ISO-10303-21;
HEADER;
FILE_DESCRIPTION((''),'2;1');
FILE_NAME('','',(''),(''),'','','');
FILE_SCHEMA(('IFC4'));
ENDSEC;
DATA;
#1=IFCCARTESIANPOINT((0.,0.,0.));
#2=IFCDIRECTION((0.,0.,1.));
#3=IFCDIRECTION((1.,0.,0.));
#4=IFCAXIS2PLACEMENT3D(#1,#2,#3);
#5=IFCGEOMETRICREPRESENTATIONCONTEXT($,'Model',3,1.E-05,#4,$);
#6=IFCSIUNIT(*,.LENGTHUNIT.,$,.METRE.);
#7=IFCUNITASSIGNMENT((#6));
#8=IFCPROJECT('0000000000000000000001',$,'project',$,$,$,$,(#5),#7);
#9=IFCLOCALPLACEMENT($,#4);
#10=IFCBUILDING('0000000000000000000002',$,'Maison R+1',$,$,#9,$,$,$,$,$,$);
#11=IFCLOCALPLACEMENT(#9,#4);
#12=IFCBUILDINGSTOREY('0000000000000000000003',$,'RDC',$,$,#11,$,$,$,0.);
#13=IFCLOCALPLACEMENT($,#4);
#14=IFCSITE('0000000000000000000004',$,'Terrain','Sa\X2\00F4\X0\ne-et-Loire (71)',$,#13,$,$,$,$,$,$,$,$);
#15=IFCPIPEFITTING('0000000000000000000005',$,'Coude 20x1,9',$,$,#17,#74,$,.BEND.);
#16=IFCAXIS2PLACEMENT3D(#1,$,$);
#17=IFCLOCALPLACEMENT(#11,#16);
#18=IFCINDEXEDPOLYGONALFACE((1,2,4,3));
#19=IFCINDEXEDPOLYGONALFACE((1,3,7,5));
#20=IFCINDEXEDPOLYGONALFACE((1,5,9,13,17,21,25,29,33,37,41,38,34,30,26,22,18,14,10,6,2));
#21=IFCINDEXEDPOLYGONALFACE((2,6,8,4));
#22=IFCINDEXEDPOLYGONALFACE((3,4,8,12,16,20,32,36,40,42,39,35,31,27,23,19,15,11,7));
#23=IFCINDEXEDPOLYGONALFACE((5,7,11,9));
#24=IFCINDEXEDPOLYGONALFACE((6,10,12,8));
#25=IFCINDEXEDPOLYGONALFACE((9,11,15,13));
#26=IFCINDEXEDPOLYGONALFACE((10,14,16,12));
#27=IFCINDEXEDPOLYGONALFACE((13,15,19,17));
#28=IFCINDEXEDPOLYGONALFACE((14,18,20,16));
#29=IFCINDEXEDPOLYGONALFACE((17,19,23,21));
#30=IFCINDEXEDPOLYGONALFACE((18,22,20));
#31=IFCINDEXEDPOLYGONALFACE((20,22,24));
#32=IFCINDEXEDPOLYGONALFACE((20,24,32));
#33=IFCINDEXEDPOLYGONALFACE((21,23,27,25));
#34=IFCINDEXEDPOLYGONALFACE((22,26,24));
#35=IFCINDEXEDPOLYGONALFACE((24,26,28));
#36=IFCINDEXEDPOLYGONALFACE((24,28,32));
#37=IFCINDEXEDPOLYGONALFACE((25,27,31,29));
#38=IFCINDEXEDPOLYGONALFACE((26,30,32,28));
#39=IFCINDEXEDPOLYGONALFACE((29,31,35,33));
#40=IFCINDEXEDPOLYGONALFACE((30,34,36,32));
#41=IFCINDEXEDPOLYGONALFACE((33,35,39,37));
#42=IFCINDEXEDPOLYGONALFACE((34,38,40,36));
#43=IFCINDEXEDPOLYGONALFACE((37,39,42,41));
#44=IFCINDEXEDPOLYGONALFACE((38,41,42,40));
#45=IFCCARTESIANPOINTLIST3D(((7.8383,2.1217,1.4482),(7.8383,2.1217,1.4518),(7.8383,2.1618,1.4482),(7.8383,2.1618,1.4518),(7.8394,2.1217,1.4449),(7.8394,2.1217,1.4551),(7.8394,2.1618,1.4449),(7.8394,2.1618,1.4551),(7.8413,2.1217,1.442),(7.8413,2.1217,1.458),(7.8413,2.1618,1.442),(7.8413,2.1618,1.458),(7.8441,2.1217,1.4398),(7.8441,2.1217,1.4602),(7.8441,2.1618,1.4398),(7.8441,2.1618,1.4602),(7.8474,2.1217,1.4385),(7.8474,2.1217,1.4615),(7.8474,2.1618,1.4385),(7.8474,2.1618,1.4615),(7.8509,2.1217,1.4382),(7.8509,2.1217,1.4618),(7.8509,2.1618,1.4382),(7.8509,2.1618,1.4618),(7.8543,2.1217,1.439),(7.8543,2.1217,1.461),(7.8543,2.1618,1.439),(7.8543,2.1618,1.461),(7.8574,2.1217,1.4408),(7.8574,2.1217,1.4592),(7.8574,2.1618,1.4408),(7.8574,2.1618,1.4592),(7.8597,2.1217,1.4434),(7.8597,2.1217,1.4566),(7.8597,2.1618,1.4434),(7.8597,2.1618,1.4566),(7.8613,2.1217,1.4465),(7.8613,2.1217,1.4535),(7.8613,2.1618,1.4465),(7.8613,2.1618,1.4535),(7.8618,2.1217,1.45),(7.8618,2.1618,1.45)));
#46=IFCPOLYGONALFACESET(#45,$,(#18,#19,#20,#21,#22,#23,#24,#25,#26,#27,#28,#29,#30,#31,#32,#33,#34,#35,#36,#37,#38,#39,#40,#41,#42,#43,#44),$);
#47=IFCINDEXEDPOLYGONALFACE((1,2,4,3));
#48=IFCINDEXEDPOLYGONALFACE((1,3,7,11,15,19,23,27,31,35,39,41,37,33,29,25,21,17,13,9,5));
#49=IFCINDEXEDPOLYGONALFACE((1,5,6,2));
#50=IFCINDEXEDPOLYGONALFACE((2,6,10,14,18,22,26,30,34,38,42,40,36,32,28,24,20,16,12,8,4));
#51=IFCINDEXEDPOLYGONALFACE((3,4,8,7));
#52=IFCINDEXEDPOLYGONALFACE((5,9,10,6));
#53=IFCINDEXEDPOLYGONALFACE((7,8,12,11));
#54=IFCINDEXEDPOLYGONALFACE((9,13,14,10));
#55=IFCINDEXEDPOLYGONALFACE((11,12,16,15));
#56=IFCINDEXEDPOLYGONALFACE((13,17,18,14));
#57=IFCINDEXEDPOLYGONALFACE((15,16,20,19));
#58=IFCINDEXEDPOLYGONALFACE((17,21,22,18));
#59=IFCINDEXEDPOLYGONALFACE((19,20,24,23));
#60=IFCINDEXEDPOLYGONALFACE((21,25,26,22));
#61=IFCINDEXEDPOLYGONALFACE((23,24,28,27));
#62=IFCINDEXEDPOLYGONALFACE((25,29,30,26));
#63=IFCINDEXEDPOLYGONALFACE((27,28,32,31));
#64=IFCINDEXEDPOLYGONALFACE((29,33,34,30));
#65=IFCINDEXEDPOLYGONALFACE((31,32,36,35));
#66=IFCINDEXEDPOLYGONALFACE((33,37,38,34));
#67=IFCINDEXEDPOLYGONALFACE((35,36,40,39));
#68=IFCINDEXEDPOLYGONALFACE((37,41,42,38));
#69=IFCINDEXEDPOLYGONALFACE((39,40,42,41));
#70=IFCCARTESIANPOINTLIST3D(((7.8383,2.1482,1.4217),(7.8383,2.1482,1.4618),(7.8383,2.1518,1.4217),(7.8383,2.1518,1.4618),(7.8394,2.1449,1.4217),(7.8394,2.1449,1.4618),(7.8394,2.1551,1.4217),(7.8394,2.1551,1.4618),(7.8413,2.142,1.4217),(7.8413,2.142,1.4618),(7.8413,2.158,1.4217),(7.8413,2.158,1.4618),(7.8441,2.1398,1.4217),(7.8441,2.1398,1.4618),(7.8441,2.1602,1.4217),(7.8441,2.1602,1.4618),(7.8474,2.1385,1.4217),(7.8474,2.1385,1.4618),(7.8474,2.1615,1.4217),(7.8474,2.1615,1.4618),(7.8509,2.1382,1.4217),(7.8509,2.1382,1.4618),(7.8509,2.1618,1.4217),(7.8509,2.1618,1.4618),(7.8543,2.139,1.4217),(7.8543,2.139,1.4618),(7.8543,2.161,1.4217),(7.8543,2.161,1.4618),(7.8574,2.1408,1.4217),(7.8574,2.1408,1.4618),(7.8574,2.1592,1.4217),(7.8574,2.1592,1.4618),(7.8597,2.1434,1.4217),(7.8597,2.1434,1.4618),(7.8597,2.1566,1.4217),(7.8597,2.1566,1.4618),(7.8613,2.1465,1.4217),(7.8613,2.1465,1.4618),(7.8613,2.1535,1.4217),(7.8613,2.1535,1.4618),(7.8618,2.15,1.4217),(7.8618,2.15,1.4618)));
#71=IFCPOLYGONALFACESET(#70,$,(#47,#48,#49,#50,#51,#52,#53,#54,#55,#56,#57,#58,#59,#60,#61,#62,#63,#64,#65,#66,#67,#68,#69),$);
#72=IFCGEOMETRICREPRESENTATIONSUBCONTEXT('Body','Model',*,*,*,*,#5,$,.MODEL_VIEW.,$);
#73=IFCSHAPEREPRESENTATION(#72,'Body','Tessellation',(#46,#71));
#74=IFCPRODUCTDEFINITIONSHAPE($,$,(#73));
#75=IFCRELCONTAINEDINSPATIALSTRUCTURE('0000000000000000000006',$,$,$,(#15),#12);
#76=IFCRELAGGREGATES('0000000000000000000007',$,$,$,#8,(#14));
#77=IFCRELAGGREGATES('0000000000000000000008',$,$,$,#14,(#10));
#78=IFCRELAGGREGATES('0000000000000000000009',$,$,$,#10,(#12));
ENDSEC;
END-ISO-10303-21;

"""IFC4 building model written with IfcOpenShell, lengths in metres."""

from ifc_helpers import new_model, si_unit, frame, origin_with_axes, place, context, subcontext, project, spatial, circle, extrude, element, save


model = new_model("IFC4")

# Units and contexts
model_context = context("Model", 3, precision=1e-05, world=origin_with_axes())
body_context = subcontext(model_context, "Body", "Model", "MODEL_VIEW")
ifc_project = project(units=[si_unit("LENGTHUNIT", "METRE")], contexts=[model_context])

# Site, building, storey
site_placement = place(None, origin_with_axes())
site = spatial("IfcSite", under=ifc_project, at=site_placement, Name="Terrain", Description="Saône-et-Loire (71)")
building_placement = place(None, origin_with_axes())
building = spatial("IfcBuilding", under=site, at=building_placement, Name="Maison R+1")
storey_placement = place(building_placement, origin_with_axes())
storey = spatial("IfcBuildingStorey", under=building, at=storey_placement, Name="RDC", Elevation=0.0)

# Pipe fitting
pipe_fitting_1_placement = place(storey_placement, frame((7.85, 2.15, 1.45), z_axis=(0.0, 0.0, 1.0), x_axis=(1.0, 0.0, 0.0)))
element("IfcPipeFitting", 1, at=pipe_fitting_1_placement, inside=storey, Name="Coude 20x1,9", PredefinedType="BEND", context=body_context, shape_type="SweptSolid", body=[
    extrude(circle(Radius=0.0118), frame((0.0, 0.0118, 0.0), z_axis=(0.0, -1.0, 0.0), x_axis=(1.0, 0.0, 0.0)), (0.0, 0.0, 1.0), 0.0401),
    extrude(circle(Radius=0.0118), frame((0.0, 0.0, 0.0118), z_axis=(0.0, 0.0, -1.0), x_axis=(1.0, 0.0, 0.0)), (0.0, 0.0, 1.0), 0.0401),
])

save(model, "model.ifc")
